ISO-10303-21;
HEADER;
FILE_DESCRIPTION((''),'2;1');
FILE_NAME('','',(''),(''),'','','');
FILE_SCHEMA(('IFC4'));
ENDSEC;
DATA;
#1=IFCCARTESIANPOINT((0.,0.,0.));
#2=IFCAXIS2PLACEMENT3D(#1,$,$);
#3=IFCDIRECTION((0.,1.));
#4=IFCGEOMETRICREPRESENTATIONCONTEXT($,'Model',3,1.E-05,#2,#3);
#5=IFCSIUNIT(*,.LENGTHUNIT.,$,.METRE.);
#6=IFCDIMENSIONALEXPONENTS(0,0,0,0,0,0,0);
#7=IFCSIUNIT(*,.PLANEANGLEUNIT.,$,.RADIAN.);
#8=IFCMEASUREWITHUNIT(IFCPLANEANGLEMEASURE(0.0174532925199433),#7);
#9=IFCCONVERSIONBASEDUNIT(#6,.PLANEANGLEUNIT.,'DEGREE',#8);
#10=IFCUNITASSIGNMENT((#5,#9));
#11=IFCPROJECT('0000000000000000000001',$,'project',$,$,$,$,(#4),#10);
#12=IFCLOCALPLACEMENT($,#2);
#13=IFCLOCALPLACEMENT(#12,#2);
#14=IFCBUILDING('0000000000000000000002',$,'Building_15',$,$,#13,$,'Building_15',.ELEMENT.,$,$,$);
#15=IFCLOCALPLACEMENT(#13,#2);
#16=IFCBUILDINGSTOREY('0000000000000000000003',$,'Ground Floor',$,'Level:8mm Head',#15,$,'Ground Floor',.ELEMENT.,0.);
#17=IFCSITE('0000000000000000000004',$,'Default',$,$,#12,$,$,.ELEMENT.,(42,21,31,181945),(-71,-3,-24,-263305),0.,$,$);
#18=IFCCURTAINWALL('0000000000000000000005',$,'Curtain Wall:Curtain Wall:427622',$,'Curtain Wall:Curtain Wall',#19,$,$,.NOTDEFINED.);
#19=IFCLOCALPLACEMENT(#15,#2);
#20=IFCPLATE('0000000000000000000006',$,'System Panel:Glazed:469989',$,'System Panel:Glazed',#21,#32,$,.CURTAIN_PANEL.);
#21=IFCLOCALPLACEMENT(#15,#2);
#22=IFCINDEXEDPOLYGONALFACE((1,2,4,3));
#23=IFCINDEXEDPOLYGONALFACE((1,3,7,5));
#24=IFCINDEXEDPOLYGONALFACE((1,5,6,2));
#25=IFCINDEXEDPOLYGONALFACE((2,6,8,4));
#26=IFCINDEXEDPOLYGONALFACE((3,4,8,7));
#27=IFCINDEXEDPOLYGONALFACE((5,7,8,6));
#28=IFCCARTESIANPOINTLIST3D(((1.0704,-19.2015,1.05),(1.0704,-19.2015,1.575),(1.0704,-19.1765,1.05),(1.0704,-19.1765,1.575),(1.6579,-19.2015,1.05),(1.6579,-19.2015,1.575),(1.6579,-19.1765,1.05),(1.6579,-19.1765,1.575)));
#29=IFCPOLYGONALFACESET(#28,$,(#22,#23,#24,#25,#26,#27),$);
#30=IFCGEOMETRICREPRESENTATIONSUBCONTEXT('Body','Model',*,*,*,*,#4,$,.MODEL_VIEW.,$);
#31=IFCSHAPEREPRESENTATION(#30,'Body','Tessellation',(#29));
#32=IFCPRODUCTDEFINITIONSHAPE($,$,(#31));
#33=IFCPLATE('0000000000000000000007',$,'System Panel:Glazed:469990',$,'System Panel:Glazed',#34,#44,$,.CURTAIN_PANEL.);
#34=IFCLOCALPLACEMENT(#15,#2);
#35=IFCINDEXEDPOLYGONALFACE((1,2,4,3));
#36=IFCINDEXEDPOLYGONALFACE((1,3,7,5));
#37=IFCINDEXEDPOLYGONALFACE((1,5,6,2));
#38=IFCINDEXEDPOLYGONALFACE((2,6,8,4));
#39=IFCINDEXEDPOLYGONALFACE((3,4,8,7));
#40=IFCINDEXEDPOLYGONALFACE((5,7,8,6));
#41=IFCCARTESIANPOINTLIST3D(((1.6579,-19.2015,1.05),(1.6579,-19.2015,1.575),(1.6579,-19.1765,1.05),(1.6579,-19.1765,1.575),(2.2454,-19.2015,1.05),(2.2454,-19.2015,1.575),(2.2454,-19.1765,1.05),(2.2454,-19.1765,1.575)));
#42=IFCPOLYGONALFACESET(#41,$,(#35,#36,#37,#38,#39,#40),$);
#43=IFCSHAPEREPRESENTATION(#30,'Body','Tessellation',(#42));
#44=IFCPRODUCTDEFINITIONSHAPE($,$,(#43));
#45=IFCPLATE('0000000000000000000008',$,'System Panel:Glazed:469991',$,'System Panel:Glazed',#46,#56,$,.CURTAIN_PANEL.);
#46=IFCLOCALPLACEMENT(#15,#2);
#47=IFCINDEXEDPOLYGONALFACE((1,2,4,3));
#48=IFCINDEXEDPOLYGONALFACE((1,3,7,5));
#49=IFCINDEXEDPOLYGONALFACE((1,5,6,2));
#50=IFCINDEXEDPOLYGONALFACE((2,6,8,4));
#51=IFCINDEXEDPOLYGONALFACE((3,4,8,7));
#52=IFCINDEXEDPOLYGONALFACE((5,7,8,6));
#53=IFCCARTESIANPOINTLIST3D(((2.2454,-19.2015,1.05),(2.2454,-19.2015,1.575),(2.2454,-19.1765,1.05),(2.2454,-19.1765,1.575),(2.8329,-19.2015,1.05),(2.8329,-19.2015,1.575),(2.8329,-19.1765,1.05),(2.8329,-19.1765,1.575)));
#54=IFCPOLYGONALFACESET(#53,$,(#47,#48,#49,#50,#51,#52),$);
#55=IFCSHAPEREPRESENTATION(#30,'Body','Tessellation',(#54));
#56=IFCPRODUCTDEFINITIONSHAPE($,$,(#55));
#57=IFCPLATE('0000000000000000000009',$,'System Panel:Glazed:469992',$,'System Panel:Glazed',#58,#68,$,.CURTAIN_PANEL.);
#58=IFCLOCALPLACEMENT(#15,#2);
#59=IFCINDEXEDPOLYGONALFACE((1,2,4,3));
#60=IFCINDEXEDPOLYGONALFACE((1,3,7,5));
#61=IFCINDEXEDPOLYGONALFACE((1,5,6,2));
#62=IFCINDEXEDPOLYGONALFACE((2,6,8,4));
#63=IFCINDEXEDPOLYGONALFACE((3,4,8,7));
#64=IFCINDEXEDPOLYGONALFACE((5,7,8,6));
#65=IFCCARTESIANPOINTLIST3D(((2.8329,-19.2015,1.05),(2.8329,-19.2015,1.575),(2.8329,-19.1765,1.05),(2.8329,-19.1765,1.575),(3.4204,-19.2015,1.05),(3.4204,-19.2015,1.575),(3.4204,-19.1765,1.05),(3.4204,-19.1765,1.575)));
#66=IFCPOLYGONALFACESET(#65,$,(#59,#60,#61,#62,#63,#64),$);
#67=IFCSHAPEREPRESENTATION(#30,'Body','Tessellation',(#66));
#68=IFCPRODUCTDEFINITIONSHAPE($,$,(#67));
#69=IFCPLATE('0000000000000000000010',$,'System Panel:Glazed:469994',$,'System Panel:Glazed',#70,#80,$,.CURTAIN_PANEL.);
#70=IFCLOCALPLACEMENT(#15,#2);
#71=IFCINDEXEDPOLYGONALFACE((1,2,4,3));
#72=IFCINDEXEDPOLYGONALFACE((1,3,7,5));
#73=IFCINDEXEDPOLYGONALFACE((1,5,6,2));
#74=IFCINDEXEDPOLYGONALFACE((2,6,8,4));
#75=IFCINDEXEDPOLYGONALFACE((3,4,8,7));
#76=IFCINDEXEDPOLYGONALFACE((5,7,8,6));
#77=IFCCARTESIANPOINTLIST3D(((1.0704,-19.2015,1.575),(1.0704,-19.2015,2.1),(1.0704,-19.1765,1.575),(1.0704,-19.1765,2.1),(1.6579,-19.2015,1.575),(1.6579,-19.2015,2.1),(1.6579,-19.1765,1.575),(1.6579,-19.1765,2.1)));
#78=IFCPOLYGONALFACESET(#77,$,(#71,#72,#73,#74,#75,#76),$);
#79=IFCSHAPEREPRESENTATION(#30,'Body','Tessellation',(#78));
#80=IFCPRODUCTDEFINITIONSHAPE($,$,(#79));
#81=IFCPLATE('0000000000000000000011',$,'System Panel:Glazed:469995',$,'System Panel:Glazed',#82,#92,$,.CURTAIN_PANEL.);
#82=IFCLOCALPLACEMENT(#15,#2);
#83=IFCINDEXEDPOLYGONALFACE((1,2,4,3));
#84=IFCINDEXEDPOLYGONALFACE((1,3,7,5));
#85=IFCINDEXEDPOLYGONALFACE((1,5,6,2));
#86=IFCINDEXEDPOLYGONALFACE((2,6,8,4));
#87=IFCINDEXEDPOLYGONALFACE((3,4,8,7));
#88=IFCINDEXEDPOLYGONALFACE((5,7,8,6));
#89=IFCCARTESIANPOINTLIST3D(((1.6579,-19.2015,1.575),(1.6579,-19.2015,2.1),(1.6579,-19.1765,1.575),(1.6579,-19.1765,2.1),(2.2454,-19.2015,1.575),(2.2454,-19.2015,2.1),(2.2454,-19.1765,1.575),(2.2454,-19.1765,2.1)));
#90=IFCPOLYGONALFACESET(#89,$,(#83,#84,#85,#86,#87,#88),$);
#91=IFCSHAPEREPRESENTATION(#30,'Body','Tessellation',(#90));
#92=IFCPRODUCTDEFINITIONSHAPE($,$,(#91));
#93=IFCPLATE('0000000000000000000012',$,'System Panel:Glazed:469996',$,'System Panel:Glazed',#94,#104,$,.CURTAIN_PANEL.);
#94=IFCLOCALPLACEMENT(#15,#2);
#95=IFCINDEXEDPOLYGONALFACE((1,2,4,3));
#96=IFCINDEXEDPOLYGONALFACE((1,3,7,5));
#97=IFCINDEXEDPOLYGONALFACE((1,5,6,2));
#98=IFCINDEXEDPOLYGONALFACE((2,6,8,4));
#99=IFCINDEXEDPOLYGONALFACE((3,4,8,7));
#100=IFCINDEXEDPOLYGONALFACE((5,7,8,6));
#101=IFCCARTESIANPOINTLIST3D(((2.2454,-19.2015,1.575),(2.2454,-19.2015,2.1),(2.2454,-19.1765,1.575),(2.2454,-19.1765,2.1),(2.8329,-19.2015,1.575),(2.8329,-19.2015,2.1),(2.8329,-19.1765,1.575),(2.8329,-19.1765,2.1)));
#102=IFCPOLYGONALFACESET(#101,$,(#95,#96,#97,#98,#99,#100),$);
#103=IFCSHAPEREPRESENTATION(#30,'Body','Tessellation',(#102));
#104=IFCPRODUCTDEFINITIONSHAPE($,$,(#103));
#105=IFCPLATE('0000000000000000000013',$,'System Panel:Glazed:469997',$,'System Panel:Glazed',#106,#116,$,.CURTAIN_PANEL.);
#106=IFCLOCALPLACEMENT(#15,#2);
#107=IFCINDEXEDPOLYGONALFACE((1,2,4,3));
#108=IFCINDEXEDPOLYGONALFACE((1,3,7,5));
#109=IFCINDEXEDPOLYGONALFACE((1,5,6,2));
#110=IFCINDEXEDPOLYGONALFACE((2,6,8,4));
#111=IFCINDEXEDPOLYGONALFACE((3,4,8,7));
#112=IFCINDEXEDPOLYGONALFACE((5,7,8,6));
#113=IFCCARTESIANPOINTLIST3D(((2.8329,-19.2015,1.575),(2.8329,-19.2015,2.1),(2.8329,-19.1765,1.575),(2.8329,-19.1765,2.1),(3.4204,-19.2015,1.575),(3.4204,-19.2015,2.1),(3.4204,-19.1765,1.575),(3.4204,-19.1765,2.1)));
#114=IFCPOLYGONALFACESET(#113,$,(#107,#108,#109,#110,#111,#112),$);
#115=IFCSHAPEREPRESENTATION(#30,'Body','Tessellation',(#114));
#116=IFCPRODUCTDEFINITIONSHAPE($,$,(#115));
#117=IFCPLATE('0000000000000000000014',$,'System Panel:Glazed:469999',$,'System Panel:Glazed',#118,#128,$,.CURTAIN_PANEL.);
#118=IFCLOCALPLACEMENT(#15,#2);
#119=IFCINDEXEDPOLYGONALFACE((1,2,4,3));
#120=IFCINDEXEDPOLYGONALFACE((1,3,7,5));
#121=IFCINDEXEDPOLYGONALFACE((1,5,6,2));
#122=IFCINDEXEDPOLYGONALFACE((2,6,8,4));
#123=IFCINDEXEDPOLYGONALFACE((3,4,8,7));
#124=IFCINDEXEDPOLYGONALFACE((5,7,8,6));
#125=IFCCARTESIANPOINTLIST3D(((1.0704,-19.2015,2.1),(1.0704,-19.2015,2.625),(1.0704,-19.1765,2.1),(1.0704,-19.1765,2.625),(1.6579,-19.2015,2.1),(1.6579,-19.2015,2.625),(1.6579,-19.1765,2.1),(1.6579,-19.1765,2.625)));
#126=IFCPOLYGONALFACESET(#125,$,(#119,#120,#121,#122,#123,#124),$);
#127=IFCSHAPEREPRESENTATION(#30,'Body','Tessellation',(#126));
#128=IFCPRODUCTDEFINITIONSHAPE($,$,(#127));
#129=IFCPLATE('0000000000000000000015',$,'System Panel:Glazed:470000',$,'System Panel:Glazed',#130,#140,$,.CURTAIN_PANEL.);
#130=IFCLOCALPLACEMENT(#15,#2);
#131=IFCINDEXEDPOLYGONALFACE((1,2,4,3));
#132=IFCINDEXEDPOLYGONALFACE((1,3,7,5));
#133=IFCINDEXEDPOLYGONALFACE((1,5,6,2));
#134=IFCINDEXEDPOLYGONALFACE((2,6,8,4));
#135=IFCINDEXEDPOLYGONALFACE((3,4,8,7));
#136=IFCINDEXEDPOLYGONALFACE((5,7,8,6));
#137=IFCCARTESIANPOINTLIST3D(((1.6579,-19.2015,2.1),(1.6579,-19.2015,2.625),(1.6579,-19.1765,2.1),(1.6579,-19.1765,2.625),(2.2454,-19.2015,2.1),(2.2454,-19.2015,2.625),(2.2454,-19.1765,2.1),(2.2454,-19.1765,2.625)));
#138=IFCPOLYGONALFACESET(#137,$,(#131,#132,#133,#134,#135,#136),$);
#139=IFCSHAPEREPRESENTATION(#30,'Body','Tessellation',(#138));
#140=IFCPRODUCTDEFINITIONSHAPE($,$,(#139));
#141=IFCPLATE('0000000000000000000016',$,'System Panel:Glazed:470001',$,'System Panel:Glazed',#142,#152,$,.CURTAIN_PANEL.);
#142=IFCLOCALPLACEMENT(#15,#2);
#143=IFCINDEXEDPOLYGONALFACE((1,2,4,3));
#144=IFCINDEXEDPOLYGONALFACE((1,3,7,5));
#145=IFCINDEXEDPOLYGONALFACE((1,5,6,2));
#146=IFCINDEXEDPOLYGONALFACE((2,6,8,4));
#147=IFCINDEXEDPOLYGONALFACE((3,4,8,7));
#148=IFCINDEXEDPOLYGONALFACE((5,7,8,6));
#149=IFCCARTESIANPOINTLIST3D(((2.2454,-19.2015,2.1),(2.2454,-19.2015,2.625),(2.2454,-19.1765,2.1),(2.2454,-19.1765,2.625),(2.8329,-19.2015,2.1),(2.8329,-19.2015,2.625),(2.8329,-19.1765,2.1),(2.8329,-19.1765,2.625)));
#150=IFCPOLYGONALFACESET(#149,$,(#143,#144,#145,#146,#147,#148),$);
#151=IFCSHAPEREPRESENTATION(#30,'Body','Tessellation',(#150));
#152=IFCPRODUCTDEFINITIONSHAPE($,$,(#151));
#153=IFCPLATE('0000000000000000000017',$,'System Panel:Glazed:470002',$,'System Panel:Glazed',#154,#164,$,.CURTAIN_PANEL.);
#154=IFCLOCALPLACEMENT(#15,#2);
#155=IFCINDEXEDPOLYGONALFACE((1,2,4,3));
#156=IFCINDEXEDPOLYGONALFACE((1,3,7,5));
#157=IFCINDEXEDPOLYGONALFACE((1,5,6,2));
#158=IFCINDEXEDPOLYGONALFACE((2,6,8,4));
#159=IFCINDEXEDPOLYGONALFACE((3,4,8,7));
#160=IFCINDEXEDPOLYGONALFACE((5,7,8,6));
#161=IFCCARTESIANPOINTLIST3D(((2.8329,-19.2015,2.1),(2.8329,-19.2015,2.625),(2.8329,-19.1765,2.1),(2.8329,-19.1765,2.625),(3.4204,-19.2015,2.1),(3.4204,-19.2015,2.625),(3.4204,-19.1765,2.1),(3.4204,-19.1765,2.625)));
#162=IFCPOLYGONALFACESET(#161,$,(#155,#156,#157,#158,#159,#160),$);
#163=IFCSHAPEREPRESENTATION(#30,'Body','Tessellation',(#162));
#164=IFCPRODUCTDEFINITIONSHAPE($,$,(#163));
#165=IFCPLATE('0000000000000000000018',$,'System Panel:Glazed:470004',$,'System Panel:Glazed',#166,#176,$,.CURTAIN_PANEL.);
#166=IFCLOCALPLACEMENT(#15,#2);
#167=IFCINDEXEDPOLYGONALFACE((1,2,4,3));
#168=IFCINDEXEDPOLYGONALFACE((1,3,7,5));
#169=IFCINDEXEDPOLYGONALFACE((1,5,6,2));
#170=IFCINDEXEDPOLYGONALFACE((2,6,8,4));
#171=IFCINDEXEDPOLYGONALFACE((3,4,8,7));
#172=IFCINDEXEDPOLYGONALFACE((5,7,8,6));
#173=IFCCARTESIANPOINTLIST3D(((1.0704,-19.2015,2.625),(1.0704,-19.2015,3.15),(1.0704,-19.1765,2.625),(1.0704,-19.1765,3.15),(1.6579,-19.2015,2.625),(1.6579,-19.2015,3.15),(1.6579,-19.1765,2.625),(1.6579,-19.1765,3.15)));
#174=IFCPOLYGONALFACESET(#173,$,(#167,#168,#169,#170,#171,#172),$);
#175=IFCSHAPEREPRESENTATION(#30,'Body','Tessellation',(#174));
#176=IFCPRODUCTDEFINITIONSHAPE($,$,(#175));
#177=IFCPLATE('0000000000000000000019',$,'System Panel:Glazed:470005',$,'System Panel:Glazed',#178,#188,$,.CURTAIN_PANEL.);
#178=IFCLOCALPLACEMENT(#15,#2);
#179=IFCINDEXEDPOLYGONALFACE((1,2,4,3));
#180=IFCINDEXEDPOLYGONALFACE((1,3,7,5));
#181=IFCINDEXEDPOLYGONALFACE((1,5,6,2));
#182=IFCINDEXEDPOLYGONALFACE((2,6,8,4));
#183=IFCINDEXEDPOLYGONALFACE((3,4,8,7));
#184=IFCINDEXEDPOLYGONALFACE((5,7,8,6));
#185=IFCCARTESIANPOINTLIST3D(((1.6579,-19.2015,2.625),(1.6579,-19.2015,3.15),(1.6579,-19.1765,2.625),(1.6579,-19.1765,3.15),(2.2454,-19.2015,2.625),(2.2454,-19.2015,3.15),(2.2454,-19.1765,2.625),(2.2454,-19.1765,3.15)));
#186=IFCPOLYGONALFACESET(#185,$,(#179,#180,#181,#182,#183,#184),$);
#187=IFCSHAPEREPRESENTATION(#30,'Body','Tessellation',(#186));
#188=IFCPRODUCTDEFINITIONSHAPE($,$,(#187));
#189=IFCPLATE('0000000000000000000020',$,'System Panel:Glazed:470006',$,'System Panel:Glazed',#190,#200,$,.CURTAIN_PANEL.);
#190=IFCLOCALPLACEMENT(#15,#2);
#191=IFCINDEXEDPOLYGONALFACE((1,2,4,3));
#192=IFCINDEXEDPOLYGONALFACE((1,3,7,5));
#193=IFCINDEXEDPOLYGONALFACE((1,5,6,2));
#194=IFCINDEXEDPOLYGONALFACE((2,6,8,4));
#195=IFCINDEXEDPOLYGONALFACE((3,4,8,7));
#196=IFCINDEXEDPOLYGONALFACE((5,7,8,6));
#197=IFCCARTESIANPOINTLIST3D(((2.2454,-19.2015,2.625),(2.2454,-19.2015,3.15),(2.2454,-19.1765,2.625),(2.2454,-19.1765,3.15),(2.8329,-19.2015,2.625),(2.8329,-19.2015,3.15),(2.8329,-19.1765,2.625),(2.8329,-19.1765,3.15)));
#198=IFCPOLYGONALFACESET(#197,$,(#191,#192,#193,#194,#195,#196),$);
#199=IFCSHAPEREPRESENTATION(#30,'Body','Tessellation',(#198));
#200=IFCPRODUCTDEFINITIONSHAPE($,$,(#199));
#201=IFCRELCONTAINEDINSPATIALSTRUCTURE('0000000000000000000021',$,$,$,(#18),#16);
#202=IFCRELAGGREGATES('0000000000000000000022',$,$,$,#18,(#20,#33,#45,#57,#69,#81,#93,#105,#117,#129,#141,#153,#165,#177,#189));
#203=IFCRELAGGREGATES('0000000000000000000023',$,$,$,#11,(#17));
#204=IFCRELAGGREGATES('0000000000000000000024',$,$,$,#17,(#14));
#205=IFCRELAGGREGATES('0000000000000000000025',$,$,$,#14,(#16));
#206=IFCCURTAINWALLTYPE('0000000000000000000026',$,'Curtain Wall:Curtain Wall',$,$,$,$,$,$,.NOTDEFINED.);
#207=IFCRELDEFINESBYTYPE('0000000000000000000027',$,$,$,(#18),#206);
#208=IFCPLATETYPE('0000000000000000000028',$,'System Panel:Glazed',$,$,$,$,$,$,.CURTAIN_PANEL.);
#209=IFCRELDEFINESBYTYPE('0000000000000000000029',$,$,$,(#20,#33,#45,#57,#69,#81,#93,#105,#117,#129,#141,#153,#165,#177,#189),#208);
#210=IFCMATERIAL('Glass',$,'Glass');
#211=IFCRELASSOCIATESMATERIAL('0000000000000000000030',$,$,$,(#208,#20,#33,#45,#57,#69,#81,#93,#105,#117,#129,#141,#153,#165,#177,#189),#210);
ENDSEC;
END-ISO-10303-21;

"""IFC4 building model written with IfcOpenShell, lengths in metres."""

from ifc_helpers import new_model, entity, si_unit, converted_unit, direction, frame, origin, place, context, subcontext, project, spatial, indexed_curve, outline, extrude, source, transform, mapped, material, type_object, type_shapes, element, aggregate, save


model = new_model("IFC4")

# Units and contexts
model_context = context("Model", 3, precision=1e-05, world=origin(), true_north=direction((0.0, 1.0)))
body_context = subcontext(model_context, "Body", "Model", "MODEL_VIEW")
ifc_project = project(units=[si_unit("LENGTHUNIT", "METRE"), converted_unit("PLANEANGLEUNIT", "DEGREE", entity("IfcPlaneAngleMeasure", 0.0174532925199433), si_unit("PLANEANGLEUNIT", "RADIAN"), dimensions=[0, 0, 0, 0, 0, 0, 0])], contexts=[model_context])

# Site, building, storey
site_placement = place(None, origin())
site = spatial("IfcSite", under=ifc_project, at=site_placement, Name="Default", CompositionType="ELEMENT", RefLatitude=(42, 21, 31, 181945), RefLongitude=(-71, -3, -24, -263305), RefElevation=0.0)
building_placement = place(site_placement, origin())
building = spatial("IfcBuilding", under=site, at=building_placement, Name="Building_15", LongName="Building_15", CompositionType="ELEMENT")
storey_placement = place(building_placement, origin())
storey = spatial("IfcBuildingStorey", under=building, at=storey_placement, Name="Ground Floor", ObjectType="Level:8mm Head", LongName="Ground Floor", CompositionType="ELEMENT", Elevation=0.0)

# Curtain wall, plates
curtain_wall_type_1 = type_object("IfcCurtainWallType", Name="Curtain Wall:Curtain Wall", PredefinedType="NOTDEFINED")
curtain_wall_1_placement = place(storey_placement, origin())
curtain_wall_1 = element("IfcCurtainWall", 1, at=curtain_wall_1_placement, inside=storey, type_object=curtain_wall_type_1, Name="Curtain Wall:Curtain Wall:427622", ObjectType="Curtain Wall:Curtain Wall", PredefinedType="NOTDEFINED")
ifc_material_1 = material(Name="Glass", Category="Glass")
plate_type = type_object("IfcPlateType", Name="System Panel:Glazed", PredefinedType="CURTAIN_PANEL", material=ifc_material_1)
shared_shape_1 = source(origin(), body_context, "Body", "SweptSolid", [
    extrude(outline(indexed_curve([(-0.0125, -0.2938), (0.0125, -0.2938), (0.0125, 0.2938), (-0.0125, 0.2938), (-0.0125, -0.2938)], self_intersect=False)), frame((0.0, 0.037, 0.0), z_axis=(0.0, 0.0, 1.0), x_axis=(0.0, 1.0, 0.0)), (0.0, 0.0, 1.0), 0.525),
])
type_shapes(plate_type, [shared_shape_1])
plate_1_placement = place(curtain_wall_1_placement, frame((1.3641, -19.226, 1.05)))
plate_1 = element("IfcPlate", 2, at=plate_1_placement, type_object=plate_type, material=ifc_material_1, Name="System Panel:Glazed:469989", ObjectType="System Panel:Glazed", PredefinedType="CURTAIN_PANEL", context=body_context, shape_type="MappedRepresentation", body=[
    mapped(shared_shape_1, transform((0.0, 0.0, 0.0), scale=1.0)),
])
plate_2_placement = place(curtain_wall_1_placement, frame((1.9516, -19.226, 1.05)))
plate_2 = element("IfcPlate", 3, at=plate_2_placement, type_object=plate_type, material=ifc_material_1, Name="System Panel:Glazed:469990", ObjectType="System Panel:Glazed", PredefinedType="CURTAIN_PANEL", context=body_context, shape_type="MappedRepresentation", body=[
    mapped(shared_shape_1, transform((0.0, 0.0, 0.0), scale=1.0)),
])
plate_3_placement = place(curtain_wall_1_placement, frame((2.5391, -19.226, 1.05)))
plate_3 = element("IfcPlate", 4, at=plate_3_placement, type_object=plate_type, material=ifc_material_1, Name="System Panel:Glazed:469991", ObjectType="System Panel:Glazed", PredefinedType="CURTAIN_PANEL", context=body_context, shape_type="MappedRepresentation", body=[
    mapped(shared_shape_1, transform((0.0, 0.0, 0.0), scale=1.0)),
])
plate_4_placement = place(curtain_wall_1_placement, frame((3.1266, -19.226, 1.05)))
plate_4 = element("IfcPlate", 5, at=plate_4_placement, type_object=plate_type, material=ifc_material_1, Name="System Panel:Glazed:469992", ObjectType="System Panel:Glazed", PredefinedType="CURTAIN_PANEL", context=body_context, shape_type="MappedRepresentation", body=[
    mapped(shared_shape_1, transform((0.0, 0.0, 0.0), scale=1.0)),
])
plate_5_placement = place(curtain_wall_1_placement, frame((1.3641, -19.226, 1.575)))
plate_5 = element("IfcPlate", 6, at=plate_5_placement, type_object=plate_type, material=ifc_material_1, Name="System Panel:Glazed:469994", ObjectType="System Panel:Glazed", PredefinedType="CURTAIN_PANEL", context=body_context, shape_type="MappedRepresentation", body=[
    mapped(shared_shape_1, transform((0.0, 0.0, 0.0), scale=1.0)),
])
plate_6_placement = place(curtain_wall_1_placement, frame((1.9516, -19.226, 1.575)))
plate_6 = element("IfcPlate", 7, at=plate_6_placement, type_object=plate_type, material=ifc_material_1, Name="System Panel:Glazed:469995", ObjectType="System Panel:Glazed", PredefinedType="CURTAIN_PANEL", context=body_context, shape_type="MappedRepresentation", body=[
    mapped(shared_shape_1, transform((0.0, 0.0, 0.0), scale=1.0)),
])
plate_7_placement = place(curtain_wall_1_placement, frame((2.5391, -19.226, 1.575)))
plate_7 = element("IfcPlate", 8, at=plate_7_placement, type_object=plate_type, material=ifc_material_1, Name="System Panel:Glazed:469996", ObjectType="System Panel:Glazed", PredefinedType="CURTAIN_PANEL", context=body_context, shape_type="MappedRepresentation", body=[
    mapped(shared_shape_1, transform((0.0, 0.0, 0.0), scale=1.0)),
])
plate_8_placement = place(curtain_wall_1_placement, frame((3.1266, -19.226, 1.575)))
plate_8 = element("IfcPlate", 9, at=plate_8_placement, type_object=plate_type, material=ifc_material_1, Name="System Panel:Glazed:469997", ObjectType="System Panel:Glazed", PredefinedType="CURTAIN_PANEL", context=body_context, shape_type="MappedRepresentation", body=[
    mapped(shared_shape_1, transform((0.0, 0.0, 0.0), scale=1.0)),
])
plate_9_placement = place(curtain_wall_1_placement, frame((1.3641, -19.226, 2.1)))
plate_9 = element("IfcPlate", 10, at=plate_9_placement, type_object=plate_type, material=ifc_material_1, Name="System Panel:Glazed:469999", ObjectType="System Panel:Glazed", PredefinedType="CURTAIN_PANEL", context=body_context, shape_type="MappedRepresentation", body=[
    mapped(shared_shape_1, transform((0.0, 0.0, 0.0), scale=1.0)),
])
plate_10_placement = place(curtain_wall_1_placement, frame((1.9516, -19.226, 2.1)))
plate_10 = element("IfcPlate", 11, at=plate_10_placement, type_object=plate_type, material=ifc_material_1, Name="System Panel:Glazed:470000", ObjectType="System Panel:Glazed", PredefinedType="CURTAIN_PANEL", context=body_context, shape_type="MappedRepresentation", body=[
    mapped(shared_shape_1, transform((0.0, 0.0, 0.0), scale=1.0)),
])
plate_11_placement = place(curtain_wall_1_placement, frame((2.5391, -19.226, 2.1)))
plate_11 = element("IfcPlate", 12, at=plate_11_placement, type_object=plate_type, material=ifc_material_1, Name="System Panel:Glazed:470001", ObjectType="System Panel:Glazed", PredefinedType="CURTAIN_PANEL", context=body_context, shape_type="MappedRepresentation", body=[
    mapped(shared_shape_1, transform((0.0, 0.0, 0.0), scale=1.0)),
])
plate_12_placement = place(curtain_wall_1_placement, frame((3.1266, -19.226, 2.1)))
plate_12 = element("IfcPlate", 13, at=plate_12_placement, type_object=plate_type, material=ifc_material_1, Name="System Panel:Glazed:470002", ObjectType="System Panel:Glazed", PredefinedType="CURTAIN_PANEL", context=body_context, shape_type="MappedRepresentation", body=[
    mapped(shared_shape_1, transform((0.0, 0.0, 0.0), scale=1.0)),
])
plate_13_placement = place(curtain_wall_1_placement, frame((1.3641, -19.226, 2.625)))
plate_13 = element("IfcPlate", 14, at=plate_13_placement, type_object=plate_type, material=ifc_material_1, Name="System Panel:Glazed:470004", ObjectType="System Panel:Glazed", PredefinedType="CURTAIN_PANEL", context=body_context, shape_type="MappedRepresentation", body=[
    mapped(shared_shape_1, transform((0.0, 0.0, 0.0), scale=1.0)),
])
plate_14_placement = place(curtain_wall_1_placement, frame((1.9516, -19.226, 2.625)))
plate_14 = element("IfcPlate", 15, at=plate_14_placement, type_object=plate_type, material=ifc_material_1, Name="System Panel:Glazed:470005", ObjectType="System Panel:Glazed", PredefinedType="CURTAIN_PANEL", context=body_context, shape_type="MappedRepresentation", body=[
    mapped(shared_shape_1, transform((0.0, 0.0, 0.0), scale=1.0)),
])
plate_15_placement = place(curtain_wall_1_placement, frame((2.5391, -19.226, 2.625)))
plate_15 = element("IfcPlate", 16, at=plate_15_placement, type_object=plate_type, material=ifc_material_1, Name="System Panel:Glazed:470006", ObjectType="System Panel:Glazed", PredefinedType="CURTAIN_PANEL", context=body_context, shape_type="MappedRepresentation", body=[
    mapped(shared_shape_1, transform((0.0, 0.0, 0.0), scale=1.0)),
])
aggregate(curtain_wall_1, [plate_1, plate_2, plate_3, plate_4, plate_5, plate_6, plate_7, plate_8, plate_9, plate_10, plate_11, plate_12, plate_13, plate_14, plate_15])

save(model, "model.ifc")
